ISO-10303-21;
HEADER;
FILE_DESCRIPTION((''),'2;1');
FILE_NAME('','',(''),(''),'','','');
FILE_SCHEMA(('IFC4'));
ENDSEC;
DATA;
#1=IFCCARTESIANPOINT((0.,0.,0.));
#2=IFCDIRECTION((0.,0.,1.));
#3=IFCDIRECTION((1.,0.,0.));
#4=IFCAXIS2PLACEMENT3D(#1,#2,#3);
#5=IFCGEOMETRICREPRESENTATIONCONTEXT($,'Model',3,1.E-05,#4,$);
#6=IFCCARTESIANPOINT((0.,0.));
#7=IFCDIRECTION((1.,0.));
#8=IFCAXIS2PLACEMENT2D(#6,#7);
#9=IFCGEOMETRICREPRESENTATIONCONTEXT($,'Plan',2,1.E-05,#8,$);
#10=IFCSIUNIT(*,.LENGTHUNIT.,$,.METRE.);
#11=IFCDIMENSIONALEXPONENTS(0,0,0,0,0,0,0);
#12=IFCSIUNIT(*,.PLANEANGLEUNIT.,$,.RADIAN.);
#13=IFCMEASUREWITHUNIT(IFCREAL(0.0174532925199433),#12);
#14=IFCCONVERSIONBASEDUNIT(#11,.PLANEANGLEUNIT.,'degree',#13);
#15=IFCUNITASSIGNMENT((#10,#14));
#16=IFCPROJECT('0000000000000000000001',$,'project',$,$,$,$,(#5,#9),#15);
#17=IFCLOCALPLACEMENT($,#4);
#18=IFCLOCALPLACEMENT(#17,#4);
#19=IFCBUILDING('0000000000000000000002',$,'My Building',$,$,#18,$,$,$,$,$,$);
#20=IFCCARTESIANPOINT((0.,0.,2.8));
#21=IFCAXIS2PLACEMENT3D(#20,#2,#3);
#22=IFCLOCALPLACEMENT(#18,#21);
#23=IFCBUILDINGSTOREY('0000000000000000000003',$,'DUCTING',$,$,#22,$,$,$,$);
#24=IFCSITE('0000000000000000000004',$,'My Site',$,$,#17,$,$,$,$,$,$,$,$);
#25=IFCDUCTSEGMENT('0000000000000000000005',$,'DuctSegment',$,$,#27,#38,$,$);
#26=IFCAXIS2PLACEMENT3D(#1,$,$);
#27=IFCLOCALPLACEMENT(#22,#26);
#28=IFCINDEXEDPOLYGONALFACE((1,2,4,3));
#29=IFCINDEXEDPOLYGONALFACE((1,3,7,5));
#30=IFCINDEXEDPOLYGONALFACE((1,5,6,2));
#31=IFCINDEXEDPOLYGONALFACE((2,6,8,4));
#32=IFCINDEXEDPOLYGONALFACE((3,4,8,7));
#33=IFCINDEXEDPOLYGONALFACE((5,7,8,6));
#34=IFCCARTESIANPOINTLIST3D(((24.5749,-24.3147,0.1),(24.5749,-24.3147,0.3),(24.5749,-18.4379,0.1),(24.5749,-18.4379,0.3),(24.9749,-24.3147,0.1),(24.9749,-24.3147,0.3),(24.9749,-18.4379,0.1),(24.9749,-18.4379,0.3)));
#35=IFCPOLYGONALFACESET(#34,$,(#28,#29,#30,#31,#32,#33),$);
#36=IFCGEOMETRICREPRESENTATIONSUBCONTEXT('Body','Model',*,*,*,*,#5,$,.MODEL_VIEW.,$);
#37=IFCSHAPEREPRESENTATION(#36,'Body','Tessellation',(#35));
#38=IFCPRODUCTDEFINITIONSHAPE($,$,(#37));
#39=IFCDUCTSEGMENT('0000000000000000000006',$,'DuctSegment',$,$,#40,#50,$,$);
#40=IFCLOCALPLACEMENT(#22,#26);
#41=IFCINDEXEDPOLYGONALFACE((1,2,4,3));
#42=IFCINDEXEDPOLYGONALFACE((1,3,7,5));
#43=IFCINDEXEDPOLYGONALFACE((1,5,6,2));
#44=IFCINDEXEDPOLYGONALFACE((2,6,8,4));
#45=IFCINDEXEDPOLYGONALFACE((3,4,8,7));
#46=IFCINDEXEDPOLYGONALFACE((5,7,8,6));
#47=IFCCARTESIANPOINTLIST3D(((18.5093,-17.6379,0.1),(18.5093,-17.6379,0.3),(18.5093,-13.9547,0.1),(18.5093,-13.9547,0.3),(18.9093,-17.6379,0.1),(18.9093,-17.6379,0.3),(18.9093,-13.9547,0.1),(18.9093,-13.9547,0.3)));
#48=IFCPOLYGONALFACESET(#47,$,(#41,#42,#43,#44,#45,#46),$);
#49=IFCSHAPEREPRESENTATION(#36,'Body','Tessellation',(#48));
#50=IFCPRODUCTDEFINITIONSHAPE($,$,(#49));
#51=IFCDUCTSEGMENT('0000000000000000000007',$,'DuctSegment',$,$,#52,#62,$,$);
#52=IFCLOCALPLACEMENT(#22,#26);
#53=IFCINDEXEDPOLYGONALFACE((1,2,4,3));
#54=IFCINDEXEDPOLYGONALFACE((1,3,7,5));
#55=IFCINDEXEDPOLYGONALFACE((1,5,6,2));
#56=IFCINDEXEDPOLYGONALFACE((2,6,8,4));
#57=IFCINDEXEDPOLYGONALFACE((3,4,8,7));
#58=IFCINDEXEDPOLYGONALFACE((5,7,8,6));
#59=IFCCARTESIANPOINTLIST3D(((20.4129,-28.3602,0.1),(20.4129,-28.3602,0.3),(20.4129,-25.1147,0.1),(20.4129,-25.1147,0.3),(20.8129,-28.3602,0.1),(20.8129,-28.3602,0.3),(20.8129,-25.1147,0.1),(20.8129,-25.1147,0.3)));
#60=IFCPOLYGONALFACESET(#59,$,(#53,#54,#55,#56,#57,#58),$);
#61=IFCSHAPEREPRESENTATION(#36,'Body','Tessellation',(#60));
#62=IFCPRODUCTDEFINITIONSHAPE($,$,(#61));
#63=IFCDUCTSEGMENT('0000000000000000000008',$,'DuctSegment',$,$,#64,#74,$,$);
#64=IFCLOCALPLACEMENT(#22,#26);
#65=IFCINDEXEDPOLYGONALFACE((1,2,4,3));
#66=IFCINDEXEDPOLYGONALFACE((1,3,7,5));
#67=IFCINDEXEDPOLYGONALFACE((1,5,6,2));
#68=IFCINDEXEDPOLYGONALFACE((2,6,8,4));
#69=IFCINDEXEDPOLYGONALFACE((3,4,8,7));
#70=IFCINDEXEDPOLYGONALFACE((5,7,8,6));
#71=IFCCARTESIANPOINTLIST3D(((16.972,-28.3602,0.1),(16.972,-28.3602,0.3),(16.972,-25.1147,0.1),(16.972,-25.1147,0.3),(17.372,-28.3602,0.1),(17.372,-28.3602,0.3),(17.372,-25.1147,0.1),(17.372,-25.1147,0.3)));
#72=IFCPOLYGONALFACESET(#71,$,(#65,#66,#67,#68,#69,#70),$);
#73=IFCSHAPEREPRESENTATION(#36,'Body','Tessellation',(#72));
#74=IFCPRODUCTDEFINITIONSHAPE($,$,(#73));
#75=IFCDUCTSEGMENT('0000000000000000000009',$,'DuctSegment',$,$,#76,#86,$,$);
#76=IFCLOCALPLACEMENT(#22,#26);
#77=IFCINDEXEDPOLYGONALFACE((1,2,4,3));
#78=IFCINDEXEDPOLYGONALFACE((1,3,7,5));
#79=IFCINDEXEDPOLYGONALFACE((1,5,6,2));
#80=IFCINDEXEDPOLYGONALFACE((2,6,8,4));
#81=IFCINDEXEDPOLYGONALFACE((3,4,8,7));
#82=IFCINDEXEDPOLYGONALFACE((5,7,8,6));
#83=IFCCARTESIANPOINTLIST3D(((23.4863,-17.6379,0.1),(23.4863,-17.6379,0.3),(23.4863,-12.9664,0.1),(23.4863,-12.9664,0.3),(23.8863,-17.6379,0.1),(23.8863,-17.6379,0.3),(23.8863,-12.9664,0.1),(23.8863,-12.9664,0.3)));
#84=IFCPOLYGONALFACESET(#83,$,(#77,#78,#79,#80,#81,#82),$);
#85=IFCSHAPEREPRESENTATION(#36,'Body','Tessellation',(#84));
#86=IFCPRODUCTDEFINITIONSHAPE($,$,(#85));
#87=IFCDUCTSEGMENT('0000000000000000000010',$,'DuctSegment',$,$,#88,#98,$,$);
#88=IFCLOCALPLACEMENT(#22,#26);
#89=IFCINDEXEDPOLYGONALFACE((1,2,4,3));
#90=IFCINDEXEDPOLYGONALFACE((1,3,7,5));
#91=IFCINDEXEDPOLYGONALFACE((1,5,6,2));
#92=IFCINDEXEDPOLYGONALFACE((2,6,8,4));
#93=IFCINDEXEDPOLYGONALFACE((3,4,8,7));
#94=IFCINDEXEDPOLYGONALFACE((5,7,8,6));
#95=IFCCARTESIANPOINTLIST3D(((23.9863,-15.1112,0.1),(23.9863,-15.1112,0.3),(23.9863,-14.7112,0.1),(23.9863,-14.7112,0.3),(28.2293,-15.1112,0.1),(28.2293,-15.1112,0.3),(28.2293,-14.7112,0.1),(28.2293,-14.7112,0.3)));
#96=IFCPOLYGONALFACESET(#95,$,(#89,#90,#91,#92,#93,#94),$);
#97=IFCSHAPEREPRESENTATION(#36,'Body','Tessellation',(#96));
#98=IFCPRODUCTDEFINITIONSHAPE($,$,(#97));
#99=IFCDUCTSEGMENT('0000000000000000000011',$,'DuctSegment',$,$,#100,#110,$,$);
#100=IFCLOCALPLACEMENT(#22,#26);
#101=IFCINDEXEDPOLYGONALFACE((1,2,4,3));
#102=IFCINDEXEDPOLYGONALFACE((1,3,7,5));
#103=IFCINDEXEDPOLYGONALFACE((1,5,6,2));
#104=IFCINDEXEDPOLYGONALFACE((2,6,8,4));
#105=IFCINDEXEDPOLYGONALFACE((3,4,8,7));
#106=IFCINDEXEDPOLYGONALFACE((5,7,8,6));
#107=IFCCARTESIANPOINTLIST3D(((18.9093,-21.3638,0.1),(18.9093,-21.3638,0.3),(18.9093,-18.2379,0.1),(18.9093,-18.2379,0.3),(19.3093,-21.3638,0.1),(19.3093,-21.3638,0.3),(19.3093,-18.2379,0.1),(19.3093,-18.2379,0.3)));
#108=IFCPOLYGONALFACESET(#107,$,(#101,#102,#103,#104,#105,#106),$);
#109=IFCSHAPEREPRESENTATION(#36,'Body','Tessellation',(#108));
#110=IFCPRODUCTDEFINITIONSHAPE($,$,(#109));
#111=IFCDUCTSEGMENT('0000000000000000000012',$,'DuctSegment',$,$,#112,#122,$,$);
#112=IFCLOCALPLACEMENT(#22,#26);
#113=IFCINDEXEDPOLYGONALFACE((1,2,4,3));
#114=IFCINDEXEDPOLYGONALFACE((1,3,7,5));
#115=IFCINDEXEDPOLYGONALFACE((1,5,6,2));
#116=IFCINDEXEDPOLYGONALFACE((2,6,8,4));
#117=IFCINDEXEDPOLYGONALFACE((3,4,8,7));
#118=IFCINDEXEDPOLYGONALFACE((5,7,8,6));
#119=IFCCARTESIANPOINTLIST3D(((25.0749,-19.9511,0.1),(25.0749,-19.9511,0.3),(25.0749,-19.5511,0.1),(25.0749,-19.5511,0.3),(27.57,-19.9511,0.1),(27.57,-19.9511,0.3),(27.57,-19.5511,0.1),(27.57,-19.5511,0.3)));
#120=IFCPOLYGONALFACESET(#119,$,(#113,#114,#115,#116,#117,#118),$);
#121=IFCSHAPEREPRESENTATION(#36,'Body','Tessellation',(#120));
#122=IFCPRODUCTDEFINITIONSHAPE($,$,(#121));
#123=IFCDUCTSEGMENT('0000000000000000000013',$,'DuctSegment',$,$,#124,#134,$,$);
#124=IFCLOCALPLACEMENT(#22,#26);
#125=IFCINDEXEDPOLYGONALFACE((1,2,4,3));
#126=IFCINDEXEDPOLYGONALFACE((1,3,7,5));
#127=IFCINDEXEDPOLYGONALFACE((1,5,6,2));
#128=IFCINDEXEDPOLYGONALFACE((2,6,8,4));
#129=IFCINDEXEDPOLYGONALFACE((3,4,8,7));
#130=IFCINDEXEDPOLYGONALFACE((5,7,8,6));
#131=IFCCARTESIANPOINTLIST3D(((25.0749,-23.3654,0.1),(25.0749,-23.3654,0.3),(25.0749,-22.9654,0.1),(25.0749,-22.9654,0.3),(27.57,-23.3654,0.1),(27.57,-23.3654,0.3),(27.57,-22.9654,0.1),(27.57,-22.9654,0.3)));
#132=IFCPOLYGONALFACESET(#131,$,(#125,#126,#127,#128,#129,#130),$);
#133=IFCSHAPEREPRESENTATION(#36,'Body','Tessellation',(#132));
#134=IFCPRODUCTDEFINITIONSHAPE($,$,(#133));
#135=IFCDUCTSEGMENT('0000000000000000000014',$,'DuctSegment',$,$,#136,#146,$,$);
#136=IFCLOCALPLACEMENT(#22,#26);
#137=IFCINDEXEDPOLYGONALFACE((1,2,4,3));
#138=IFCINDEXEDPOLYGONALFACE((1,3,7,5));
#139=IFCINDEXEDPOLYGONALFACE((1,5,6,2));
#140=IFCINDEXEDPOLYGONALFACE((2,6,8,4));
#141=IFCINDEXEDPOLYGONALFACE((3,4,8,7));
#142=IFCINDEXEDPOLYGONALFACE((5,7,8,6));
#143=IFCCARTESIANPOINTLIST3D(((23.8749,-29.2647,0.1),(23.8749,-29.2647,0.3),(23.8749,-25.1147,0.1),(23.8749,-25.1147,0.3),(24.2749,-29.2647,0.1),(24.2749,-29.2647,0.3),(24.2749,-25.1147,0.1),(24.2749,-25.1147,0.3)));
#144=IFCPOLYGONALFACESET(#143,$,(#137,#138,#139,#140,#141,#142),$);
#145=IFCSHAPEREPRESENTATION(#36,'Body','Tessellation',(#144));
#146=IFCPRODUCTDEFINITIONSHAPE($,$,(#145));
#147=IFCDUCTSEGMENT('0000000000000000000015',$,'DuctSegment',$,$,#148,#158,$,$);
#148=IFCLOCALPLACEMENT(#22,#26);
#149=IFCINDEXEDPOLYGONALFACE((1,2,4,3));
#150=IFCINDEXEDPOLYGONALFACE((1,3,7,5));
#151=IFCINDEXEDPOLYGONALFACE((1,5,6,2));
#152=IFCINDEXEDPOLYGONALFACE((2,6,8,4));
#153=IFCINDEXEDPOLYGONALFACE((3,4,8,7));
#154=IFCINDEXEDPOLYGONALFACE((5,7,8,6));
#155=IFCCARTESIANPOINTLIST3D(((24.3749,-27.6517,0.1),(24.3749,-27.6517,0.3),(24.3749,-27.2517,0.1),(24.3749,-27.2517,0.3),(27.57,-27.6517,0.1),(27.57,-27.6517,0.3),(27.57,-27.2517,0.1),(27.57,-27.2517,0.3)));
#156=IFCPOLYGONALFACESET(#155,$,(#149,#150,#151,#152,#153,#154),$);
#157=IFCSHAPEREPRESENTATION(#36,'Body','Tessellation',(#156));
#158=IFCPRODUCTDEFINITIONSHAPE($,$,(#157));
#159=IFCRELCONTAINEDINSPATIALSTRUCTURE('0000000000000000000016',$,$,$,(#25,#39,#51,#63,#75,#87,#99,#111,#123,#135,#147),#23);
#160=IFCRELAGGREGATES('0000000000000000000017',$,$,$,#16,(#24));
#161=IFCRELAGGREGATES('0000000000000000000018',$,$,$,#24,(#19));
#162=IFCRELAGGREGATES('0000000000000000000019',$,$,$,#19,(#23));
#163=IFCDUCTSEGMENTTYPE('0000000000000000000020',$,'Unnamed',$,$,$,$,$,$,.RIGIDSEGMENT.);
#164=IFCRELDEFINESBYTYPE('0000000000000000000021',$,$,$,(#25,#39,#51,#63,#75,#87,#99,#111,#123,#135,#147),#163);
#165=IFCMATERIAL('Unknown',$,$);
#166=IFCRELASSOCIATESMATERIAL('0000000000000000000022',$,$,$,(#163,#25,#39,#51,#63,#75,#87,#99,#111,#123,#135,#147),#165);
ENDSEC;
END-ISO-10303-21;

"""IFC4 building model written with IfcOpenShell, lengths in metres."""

from ifc_helpers import new_model, entity, si_unit, converted_unit, frame, origin_with_axes, origin_2d_with_axis, place, context, subcontext, project, spatial, rectangle, extrude, material, material_profile, profile_set, profile_usage, type_object, element, save


model = new_model("IFC4")

# Units and contexts
model_context = context("Model", 3, precision=1e-05, world=origin_with_axes())
plan_context = context("Plan", 2, precision=1e-05, world=origin_2d_with_axis())
body_context = subcontext(model_context, "Body", "Model", "MODEL_VIEW")
ifc_project = project(units=[si_unit("LENGTHUNIT", "METRE"), converted_unit("PLANEANGLEUNIT", "degree", entity("IfcReal", 0.0174532925199433), si_unit("PLANEANGLEUNIT", "RADIAN"), dimensions=[0, 0, 0, 0, 0, 0, 0])], contexts=[model_context, plan_context])

# Site, building, storey
site_placement = place(None, origin_with_axes())
site = spatial("IfcSite", under=ifc_project, at=site_placement, Name="My Site")
building_placement = place(site_placement, origin_with_axes())
building = spatial("IfcBuilding", under=site, at=building_placement, Name="My Building")
storey_placement = place(building_placement, frame((0.0, 0.0, 2.8), z_axis=(0.0, 0.0, 1.0), x_axis=(1.0, 0.0, 0.0)))
storey = spatial("IfcBuildingStorey", under=building, at=storey_placement, Name="DUCTING")

# Duct segments
ifc_material = material(Name="Unknown")
ifc_material_profile_1 = material_profile(ifc_material, rectangle(XDim=0.4, YDim=0.2))
ifc_profile_set_1 = profile_set([ifc_material_profile_1])
ifc_profile_usage_1 = profile_usage(ifc_profile_set_1, cardinal=5)
duct_segment_type = type_object("IfcDuctSegmentType", Name="Unnamed", PredefinedType="RIGIDSEGMENT", material=ifc_profile_set_1)
duct_segment_1_placement = place(storey_placement, frame((24.7749, -24.3147, 0.2), z_axis=(0.0, 1.0, 0.0), x_axis=(-1.0, 0.0, 0.0)))
element("IfcDuctSegment", 1, at=duct_segment_1_placement, inside=storey, type_object=duct_segment_type, material=ifc_profile_usage_1, Name="DuctSegment", context=body_context, shape_type="SweptSolid", body=[
    extrude(rectangle(XDim=0.4, YDim=0.2), origin_with_axes(), (0.0, 0.0, 1.0), 5.8768),
])
ifc_profile_usage_2 = profile_usage(ifc_profile_set_1, cardinal=5)
duct_segment_2_placement = place(storey_placement, frame((18.7093, -17.6379, 0.2), z_axis=(0.0, 1.0, 0.0), x_axis=(-1.0, 0.0, 0.0)))
element("IfcDuctSegment", 2, at=duct_segment_2_placement, inside=storey, type_object=duct_segment_type, material=ifc_profile_usage_2, Name="DuctSegment", context=body_context, shape_type="SweptSolid", body=[
    extrude(rectangle(XDim=0.4, YDim=0.2), origin_with_axes(), (0.0, 0.0, 1.0), 3.6833),
])
ifc_profile_usage_3 = profile_usage(ifc_profile_set_1, cardinal=5)
duct_segment_3_placement = place(storey_placement, frame((20.6129, -25.1147, 0.2), z_axis=(0.0, -1.0, 0.0), x_axis=(1.0, 0.0, 0.0)))
element("IfcDuctSegment", 3, at=duct_segment_3_placement, inside=storey, type_object=duct_segment_type, material=ifc_profile_usage_3, Name="DuctSegment", context=body_context, shape_type="SweptSolid", body=[
    extrude(rectangle(XDim=0.4, YDim=0.2), origin_with_axes(), (0.0, 0.0, 1.0), 3.2455),
])
ifc_profile_usage_4 = profile_usage(ifc_profile_set_1, cardinal=5)
duct_segment_4_placement = place(storey_placement, frame((17.172, -25.1147, 0.2), z_axis=(0.0, -1.0, 0.0), x_axis=(1.0, 0.0, 0.0)))
element("IfcDuctSegment", 4, at=duct_segment_4_placement, inside=storey, type_object=duct_segment_type, material=ifc_profile_usage_4, Name="DuctSegment", context=body_context, shape_type="SweptSolid", body=[
    extrude(rectangle(XDim=0.4, YDim=0.2), origin_with_axes(), (0.0, 0.0, 1.0), 3.2455),
])
ifc_profile_usage_5 = profile_usage(ifc_profile_set_1, cardinal=5)
duct_segment_5_placement = place(storey_placement, frame((23.6863, -17.6379, 0.2), z_axis=(0.0, 1.0, 0.0), x_axis=(-1.0, 0.0, 0.0)))
element("IfcDuctSegment", 5, at=duct_segment_5_placement, inside=storey, type_object=duct_segment_type, material=ifc_profile_usage_5, Name="DuctSegment", context=body_context, shape_type="SweptSolid", body=[
    extrude(rectangle(XDim=0.4, YDim=0.2), origin_with_axes(), (0.0, 0.0, 1.0), 4.6715),
])
ifc_profile_usage_6 = profile_usage(ifc_profile_set_1, cardinal=5)
duct_segment_6_placement = place(storey_placement, frame((23.9863, -14.9112, 0.2), z_axis=(1.0, 0.0, 0.0), x_axis=(0.0, 1.0, 0.0)))
element("IfcDuctSegment", 6, at=duct_segment_6_placement, inside=storey, type_object=duct_segment_type, material=ifc_profile_usage_6, Name="DuctSegment", context=body_context, shape_type="SweptSolid", body=[
    extrude(rectangle(XDim=0.4, YDim=0.2), origin_with_axes(), (0.0, 0.0, 1.0), 4.243),
])
ifc_profile_usage_7 = profile_usage(ifc_profile_set_1, cardinal=5)
duct_segment_7_placement = place(storey_placement, frame((19.1093, -18.2379, 0.2), z_axis=(0.0, -1.0, 0.0), x_axis=(1.0, 0.0, 0.0)))
element("IfcDuctSegment", 7, at=duct_segment_7_placement, inside=storey, type_object=duct_segment_type, material=ifc_profile_usage_7, Name="DuctSegment", context=body_context, shape_type="SweptSolid", body=[
    extrude(rectangle(XDim=0.4, YDim=0.2), origin_with_axes(), (0.0, 0.0, 1.0), 3.1259),
])
ifc_profile_usage_8 = profile_usage(ifc_profile_set_1, cardinal=5)
duct_segment_8_placement = place(storey_placement, frame((25.0749, -19.7511, 0.2), z_axis=(1.0, 0.0, 0.0), x_axis=(0.0, 1.0, 0.0)))
element("IfcDuctSegment", 8, at=duct_segment_8_placement, inside=storey, type_object=duct_segment_type, material=ifc_profile_usage_8, Name="DuctSegment", context=body_context, shape_type="SweptSolid", body=[
    extrude(rectangle(XDim=0.4, YDim=0.2), origin_with_axes(), (0.0, 0.0, 1.0), 2.495),
])
ifc_profile_usage_9 = profile_usage(ifc_profile_set_1, cardinal=5)
duct_segment_9_placement = place(storey_placement, frame((25.0749, -23.1654, 0.2), z_axis=(1.0, 0.0, 0.0), x_axis=(0.0, 1.0, 0.0)))
element("IfcDuctSegment", 9, at=duct_segment_9_placement, inside=storey, type_object=duct_segment_type, material=ifc_profile_usage_9, Name="DuctSegment", context=body_context, shape_type="SweptSolid", body=[
    extrude(rectangle(XDim=0.4, YDim=0.2), origin_with_axes(), (0.0, 0.0, 1.0), 2.495),
])
ifc_profile_usage_10 = profile_usage(ifc_profile_set_1, cardinal=5)
duct_segment_10_placement = place(storey_placement, frame((24.0749, -25.1147, 0.2), z_axis=(0.0, -1.0, 0.0), x_axis=(1.0, 0.0, 0.0)))
element("IfcDuctSegment", 10, at=duct_segment_10_placement, inside=storey, type_object=duct_segment_type, material=ifc_profile_usage_10, Name="DuctSegment", context=body_context, shape_type="SweptSolid", body=[
    extrude(rectangle(XDim=0.4, YDim=0.2), origin_with_axes(), (0.0, 0.0, 1.0), 4.15),
])
ifc_profile_usage_11 = profile_usage(ifc_profile_set_1, cardinal=5)
duct_segment_11_placement = place(storey_placement, frame((24.3749, -27.4517, 0.2), z_axis=(1.0, 0.0, 0.0), x_axis=(0.0, 1.0, 0.0)))
element("IfcDuctSegment", 11, at=duct_segment_11_placement, inside=storey, type_object=duct_segment_type, material=ifc_profile_usage_11, Name="DuctSegment", context=body_context, shape_type="SweptSolid", body=[
    extrude(rectangle(XDim=0.4, YDim=0.2), origin_with_axes(), (0.0, 0.0, 1.0), 3.195),
])

save(model, "model.ifc")
